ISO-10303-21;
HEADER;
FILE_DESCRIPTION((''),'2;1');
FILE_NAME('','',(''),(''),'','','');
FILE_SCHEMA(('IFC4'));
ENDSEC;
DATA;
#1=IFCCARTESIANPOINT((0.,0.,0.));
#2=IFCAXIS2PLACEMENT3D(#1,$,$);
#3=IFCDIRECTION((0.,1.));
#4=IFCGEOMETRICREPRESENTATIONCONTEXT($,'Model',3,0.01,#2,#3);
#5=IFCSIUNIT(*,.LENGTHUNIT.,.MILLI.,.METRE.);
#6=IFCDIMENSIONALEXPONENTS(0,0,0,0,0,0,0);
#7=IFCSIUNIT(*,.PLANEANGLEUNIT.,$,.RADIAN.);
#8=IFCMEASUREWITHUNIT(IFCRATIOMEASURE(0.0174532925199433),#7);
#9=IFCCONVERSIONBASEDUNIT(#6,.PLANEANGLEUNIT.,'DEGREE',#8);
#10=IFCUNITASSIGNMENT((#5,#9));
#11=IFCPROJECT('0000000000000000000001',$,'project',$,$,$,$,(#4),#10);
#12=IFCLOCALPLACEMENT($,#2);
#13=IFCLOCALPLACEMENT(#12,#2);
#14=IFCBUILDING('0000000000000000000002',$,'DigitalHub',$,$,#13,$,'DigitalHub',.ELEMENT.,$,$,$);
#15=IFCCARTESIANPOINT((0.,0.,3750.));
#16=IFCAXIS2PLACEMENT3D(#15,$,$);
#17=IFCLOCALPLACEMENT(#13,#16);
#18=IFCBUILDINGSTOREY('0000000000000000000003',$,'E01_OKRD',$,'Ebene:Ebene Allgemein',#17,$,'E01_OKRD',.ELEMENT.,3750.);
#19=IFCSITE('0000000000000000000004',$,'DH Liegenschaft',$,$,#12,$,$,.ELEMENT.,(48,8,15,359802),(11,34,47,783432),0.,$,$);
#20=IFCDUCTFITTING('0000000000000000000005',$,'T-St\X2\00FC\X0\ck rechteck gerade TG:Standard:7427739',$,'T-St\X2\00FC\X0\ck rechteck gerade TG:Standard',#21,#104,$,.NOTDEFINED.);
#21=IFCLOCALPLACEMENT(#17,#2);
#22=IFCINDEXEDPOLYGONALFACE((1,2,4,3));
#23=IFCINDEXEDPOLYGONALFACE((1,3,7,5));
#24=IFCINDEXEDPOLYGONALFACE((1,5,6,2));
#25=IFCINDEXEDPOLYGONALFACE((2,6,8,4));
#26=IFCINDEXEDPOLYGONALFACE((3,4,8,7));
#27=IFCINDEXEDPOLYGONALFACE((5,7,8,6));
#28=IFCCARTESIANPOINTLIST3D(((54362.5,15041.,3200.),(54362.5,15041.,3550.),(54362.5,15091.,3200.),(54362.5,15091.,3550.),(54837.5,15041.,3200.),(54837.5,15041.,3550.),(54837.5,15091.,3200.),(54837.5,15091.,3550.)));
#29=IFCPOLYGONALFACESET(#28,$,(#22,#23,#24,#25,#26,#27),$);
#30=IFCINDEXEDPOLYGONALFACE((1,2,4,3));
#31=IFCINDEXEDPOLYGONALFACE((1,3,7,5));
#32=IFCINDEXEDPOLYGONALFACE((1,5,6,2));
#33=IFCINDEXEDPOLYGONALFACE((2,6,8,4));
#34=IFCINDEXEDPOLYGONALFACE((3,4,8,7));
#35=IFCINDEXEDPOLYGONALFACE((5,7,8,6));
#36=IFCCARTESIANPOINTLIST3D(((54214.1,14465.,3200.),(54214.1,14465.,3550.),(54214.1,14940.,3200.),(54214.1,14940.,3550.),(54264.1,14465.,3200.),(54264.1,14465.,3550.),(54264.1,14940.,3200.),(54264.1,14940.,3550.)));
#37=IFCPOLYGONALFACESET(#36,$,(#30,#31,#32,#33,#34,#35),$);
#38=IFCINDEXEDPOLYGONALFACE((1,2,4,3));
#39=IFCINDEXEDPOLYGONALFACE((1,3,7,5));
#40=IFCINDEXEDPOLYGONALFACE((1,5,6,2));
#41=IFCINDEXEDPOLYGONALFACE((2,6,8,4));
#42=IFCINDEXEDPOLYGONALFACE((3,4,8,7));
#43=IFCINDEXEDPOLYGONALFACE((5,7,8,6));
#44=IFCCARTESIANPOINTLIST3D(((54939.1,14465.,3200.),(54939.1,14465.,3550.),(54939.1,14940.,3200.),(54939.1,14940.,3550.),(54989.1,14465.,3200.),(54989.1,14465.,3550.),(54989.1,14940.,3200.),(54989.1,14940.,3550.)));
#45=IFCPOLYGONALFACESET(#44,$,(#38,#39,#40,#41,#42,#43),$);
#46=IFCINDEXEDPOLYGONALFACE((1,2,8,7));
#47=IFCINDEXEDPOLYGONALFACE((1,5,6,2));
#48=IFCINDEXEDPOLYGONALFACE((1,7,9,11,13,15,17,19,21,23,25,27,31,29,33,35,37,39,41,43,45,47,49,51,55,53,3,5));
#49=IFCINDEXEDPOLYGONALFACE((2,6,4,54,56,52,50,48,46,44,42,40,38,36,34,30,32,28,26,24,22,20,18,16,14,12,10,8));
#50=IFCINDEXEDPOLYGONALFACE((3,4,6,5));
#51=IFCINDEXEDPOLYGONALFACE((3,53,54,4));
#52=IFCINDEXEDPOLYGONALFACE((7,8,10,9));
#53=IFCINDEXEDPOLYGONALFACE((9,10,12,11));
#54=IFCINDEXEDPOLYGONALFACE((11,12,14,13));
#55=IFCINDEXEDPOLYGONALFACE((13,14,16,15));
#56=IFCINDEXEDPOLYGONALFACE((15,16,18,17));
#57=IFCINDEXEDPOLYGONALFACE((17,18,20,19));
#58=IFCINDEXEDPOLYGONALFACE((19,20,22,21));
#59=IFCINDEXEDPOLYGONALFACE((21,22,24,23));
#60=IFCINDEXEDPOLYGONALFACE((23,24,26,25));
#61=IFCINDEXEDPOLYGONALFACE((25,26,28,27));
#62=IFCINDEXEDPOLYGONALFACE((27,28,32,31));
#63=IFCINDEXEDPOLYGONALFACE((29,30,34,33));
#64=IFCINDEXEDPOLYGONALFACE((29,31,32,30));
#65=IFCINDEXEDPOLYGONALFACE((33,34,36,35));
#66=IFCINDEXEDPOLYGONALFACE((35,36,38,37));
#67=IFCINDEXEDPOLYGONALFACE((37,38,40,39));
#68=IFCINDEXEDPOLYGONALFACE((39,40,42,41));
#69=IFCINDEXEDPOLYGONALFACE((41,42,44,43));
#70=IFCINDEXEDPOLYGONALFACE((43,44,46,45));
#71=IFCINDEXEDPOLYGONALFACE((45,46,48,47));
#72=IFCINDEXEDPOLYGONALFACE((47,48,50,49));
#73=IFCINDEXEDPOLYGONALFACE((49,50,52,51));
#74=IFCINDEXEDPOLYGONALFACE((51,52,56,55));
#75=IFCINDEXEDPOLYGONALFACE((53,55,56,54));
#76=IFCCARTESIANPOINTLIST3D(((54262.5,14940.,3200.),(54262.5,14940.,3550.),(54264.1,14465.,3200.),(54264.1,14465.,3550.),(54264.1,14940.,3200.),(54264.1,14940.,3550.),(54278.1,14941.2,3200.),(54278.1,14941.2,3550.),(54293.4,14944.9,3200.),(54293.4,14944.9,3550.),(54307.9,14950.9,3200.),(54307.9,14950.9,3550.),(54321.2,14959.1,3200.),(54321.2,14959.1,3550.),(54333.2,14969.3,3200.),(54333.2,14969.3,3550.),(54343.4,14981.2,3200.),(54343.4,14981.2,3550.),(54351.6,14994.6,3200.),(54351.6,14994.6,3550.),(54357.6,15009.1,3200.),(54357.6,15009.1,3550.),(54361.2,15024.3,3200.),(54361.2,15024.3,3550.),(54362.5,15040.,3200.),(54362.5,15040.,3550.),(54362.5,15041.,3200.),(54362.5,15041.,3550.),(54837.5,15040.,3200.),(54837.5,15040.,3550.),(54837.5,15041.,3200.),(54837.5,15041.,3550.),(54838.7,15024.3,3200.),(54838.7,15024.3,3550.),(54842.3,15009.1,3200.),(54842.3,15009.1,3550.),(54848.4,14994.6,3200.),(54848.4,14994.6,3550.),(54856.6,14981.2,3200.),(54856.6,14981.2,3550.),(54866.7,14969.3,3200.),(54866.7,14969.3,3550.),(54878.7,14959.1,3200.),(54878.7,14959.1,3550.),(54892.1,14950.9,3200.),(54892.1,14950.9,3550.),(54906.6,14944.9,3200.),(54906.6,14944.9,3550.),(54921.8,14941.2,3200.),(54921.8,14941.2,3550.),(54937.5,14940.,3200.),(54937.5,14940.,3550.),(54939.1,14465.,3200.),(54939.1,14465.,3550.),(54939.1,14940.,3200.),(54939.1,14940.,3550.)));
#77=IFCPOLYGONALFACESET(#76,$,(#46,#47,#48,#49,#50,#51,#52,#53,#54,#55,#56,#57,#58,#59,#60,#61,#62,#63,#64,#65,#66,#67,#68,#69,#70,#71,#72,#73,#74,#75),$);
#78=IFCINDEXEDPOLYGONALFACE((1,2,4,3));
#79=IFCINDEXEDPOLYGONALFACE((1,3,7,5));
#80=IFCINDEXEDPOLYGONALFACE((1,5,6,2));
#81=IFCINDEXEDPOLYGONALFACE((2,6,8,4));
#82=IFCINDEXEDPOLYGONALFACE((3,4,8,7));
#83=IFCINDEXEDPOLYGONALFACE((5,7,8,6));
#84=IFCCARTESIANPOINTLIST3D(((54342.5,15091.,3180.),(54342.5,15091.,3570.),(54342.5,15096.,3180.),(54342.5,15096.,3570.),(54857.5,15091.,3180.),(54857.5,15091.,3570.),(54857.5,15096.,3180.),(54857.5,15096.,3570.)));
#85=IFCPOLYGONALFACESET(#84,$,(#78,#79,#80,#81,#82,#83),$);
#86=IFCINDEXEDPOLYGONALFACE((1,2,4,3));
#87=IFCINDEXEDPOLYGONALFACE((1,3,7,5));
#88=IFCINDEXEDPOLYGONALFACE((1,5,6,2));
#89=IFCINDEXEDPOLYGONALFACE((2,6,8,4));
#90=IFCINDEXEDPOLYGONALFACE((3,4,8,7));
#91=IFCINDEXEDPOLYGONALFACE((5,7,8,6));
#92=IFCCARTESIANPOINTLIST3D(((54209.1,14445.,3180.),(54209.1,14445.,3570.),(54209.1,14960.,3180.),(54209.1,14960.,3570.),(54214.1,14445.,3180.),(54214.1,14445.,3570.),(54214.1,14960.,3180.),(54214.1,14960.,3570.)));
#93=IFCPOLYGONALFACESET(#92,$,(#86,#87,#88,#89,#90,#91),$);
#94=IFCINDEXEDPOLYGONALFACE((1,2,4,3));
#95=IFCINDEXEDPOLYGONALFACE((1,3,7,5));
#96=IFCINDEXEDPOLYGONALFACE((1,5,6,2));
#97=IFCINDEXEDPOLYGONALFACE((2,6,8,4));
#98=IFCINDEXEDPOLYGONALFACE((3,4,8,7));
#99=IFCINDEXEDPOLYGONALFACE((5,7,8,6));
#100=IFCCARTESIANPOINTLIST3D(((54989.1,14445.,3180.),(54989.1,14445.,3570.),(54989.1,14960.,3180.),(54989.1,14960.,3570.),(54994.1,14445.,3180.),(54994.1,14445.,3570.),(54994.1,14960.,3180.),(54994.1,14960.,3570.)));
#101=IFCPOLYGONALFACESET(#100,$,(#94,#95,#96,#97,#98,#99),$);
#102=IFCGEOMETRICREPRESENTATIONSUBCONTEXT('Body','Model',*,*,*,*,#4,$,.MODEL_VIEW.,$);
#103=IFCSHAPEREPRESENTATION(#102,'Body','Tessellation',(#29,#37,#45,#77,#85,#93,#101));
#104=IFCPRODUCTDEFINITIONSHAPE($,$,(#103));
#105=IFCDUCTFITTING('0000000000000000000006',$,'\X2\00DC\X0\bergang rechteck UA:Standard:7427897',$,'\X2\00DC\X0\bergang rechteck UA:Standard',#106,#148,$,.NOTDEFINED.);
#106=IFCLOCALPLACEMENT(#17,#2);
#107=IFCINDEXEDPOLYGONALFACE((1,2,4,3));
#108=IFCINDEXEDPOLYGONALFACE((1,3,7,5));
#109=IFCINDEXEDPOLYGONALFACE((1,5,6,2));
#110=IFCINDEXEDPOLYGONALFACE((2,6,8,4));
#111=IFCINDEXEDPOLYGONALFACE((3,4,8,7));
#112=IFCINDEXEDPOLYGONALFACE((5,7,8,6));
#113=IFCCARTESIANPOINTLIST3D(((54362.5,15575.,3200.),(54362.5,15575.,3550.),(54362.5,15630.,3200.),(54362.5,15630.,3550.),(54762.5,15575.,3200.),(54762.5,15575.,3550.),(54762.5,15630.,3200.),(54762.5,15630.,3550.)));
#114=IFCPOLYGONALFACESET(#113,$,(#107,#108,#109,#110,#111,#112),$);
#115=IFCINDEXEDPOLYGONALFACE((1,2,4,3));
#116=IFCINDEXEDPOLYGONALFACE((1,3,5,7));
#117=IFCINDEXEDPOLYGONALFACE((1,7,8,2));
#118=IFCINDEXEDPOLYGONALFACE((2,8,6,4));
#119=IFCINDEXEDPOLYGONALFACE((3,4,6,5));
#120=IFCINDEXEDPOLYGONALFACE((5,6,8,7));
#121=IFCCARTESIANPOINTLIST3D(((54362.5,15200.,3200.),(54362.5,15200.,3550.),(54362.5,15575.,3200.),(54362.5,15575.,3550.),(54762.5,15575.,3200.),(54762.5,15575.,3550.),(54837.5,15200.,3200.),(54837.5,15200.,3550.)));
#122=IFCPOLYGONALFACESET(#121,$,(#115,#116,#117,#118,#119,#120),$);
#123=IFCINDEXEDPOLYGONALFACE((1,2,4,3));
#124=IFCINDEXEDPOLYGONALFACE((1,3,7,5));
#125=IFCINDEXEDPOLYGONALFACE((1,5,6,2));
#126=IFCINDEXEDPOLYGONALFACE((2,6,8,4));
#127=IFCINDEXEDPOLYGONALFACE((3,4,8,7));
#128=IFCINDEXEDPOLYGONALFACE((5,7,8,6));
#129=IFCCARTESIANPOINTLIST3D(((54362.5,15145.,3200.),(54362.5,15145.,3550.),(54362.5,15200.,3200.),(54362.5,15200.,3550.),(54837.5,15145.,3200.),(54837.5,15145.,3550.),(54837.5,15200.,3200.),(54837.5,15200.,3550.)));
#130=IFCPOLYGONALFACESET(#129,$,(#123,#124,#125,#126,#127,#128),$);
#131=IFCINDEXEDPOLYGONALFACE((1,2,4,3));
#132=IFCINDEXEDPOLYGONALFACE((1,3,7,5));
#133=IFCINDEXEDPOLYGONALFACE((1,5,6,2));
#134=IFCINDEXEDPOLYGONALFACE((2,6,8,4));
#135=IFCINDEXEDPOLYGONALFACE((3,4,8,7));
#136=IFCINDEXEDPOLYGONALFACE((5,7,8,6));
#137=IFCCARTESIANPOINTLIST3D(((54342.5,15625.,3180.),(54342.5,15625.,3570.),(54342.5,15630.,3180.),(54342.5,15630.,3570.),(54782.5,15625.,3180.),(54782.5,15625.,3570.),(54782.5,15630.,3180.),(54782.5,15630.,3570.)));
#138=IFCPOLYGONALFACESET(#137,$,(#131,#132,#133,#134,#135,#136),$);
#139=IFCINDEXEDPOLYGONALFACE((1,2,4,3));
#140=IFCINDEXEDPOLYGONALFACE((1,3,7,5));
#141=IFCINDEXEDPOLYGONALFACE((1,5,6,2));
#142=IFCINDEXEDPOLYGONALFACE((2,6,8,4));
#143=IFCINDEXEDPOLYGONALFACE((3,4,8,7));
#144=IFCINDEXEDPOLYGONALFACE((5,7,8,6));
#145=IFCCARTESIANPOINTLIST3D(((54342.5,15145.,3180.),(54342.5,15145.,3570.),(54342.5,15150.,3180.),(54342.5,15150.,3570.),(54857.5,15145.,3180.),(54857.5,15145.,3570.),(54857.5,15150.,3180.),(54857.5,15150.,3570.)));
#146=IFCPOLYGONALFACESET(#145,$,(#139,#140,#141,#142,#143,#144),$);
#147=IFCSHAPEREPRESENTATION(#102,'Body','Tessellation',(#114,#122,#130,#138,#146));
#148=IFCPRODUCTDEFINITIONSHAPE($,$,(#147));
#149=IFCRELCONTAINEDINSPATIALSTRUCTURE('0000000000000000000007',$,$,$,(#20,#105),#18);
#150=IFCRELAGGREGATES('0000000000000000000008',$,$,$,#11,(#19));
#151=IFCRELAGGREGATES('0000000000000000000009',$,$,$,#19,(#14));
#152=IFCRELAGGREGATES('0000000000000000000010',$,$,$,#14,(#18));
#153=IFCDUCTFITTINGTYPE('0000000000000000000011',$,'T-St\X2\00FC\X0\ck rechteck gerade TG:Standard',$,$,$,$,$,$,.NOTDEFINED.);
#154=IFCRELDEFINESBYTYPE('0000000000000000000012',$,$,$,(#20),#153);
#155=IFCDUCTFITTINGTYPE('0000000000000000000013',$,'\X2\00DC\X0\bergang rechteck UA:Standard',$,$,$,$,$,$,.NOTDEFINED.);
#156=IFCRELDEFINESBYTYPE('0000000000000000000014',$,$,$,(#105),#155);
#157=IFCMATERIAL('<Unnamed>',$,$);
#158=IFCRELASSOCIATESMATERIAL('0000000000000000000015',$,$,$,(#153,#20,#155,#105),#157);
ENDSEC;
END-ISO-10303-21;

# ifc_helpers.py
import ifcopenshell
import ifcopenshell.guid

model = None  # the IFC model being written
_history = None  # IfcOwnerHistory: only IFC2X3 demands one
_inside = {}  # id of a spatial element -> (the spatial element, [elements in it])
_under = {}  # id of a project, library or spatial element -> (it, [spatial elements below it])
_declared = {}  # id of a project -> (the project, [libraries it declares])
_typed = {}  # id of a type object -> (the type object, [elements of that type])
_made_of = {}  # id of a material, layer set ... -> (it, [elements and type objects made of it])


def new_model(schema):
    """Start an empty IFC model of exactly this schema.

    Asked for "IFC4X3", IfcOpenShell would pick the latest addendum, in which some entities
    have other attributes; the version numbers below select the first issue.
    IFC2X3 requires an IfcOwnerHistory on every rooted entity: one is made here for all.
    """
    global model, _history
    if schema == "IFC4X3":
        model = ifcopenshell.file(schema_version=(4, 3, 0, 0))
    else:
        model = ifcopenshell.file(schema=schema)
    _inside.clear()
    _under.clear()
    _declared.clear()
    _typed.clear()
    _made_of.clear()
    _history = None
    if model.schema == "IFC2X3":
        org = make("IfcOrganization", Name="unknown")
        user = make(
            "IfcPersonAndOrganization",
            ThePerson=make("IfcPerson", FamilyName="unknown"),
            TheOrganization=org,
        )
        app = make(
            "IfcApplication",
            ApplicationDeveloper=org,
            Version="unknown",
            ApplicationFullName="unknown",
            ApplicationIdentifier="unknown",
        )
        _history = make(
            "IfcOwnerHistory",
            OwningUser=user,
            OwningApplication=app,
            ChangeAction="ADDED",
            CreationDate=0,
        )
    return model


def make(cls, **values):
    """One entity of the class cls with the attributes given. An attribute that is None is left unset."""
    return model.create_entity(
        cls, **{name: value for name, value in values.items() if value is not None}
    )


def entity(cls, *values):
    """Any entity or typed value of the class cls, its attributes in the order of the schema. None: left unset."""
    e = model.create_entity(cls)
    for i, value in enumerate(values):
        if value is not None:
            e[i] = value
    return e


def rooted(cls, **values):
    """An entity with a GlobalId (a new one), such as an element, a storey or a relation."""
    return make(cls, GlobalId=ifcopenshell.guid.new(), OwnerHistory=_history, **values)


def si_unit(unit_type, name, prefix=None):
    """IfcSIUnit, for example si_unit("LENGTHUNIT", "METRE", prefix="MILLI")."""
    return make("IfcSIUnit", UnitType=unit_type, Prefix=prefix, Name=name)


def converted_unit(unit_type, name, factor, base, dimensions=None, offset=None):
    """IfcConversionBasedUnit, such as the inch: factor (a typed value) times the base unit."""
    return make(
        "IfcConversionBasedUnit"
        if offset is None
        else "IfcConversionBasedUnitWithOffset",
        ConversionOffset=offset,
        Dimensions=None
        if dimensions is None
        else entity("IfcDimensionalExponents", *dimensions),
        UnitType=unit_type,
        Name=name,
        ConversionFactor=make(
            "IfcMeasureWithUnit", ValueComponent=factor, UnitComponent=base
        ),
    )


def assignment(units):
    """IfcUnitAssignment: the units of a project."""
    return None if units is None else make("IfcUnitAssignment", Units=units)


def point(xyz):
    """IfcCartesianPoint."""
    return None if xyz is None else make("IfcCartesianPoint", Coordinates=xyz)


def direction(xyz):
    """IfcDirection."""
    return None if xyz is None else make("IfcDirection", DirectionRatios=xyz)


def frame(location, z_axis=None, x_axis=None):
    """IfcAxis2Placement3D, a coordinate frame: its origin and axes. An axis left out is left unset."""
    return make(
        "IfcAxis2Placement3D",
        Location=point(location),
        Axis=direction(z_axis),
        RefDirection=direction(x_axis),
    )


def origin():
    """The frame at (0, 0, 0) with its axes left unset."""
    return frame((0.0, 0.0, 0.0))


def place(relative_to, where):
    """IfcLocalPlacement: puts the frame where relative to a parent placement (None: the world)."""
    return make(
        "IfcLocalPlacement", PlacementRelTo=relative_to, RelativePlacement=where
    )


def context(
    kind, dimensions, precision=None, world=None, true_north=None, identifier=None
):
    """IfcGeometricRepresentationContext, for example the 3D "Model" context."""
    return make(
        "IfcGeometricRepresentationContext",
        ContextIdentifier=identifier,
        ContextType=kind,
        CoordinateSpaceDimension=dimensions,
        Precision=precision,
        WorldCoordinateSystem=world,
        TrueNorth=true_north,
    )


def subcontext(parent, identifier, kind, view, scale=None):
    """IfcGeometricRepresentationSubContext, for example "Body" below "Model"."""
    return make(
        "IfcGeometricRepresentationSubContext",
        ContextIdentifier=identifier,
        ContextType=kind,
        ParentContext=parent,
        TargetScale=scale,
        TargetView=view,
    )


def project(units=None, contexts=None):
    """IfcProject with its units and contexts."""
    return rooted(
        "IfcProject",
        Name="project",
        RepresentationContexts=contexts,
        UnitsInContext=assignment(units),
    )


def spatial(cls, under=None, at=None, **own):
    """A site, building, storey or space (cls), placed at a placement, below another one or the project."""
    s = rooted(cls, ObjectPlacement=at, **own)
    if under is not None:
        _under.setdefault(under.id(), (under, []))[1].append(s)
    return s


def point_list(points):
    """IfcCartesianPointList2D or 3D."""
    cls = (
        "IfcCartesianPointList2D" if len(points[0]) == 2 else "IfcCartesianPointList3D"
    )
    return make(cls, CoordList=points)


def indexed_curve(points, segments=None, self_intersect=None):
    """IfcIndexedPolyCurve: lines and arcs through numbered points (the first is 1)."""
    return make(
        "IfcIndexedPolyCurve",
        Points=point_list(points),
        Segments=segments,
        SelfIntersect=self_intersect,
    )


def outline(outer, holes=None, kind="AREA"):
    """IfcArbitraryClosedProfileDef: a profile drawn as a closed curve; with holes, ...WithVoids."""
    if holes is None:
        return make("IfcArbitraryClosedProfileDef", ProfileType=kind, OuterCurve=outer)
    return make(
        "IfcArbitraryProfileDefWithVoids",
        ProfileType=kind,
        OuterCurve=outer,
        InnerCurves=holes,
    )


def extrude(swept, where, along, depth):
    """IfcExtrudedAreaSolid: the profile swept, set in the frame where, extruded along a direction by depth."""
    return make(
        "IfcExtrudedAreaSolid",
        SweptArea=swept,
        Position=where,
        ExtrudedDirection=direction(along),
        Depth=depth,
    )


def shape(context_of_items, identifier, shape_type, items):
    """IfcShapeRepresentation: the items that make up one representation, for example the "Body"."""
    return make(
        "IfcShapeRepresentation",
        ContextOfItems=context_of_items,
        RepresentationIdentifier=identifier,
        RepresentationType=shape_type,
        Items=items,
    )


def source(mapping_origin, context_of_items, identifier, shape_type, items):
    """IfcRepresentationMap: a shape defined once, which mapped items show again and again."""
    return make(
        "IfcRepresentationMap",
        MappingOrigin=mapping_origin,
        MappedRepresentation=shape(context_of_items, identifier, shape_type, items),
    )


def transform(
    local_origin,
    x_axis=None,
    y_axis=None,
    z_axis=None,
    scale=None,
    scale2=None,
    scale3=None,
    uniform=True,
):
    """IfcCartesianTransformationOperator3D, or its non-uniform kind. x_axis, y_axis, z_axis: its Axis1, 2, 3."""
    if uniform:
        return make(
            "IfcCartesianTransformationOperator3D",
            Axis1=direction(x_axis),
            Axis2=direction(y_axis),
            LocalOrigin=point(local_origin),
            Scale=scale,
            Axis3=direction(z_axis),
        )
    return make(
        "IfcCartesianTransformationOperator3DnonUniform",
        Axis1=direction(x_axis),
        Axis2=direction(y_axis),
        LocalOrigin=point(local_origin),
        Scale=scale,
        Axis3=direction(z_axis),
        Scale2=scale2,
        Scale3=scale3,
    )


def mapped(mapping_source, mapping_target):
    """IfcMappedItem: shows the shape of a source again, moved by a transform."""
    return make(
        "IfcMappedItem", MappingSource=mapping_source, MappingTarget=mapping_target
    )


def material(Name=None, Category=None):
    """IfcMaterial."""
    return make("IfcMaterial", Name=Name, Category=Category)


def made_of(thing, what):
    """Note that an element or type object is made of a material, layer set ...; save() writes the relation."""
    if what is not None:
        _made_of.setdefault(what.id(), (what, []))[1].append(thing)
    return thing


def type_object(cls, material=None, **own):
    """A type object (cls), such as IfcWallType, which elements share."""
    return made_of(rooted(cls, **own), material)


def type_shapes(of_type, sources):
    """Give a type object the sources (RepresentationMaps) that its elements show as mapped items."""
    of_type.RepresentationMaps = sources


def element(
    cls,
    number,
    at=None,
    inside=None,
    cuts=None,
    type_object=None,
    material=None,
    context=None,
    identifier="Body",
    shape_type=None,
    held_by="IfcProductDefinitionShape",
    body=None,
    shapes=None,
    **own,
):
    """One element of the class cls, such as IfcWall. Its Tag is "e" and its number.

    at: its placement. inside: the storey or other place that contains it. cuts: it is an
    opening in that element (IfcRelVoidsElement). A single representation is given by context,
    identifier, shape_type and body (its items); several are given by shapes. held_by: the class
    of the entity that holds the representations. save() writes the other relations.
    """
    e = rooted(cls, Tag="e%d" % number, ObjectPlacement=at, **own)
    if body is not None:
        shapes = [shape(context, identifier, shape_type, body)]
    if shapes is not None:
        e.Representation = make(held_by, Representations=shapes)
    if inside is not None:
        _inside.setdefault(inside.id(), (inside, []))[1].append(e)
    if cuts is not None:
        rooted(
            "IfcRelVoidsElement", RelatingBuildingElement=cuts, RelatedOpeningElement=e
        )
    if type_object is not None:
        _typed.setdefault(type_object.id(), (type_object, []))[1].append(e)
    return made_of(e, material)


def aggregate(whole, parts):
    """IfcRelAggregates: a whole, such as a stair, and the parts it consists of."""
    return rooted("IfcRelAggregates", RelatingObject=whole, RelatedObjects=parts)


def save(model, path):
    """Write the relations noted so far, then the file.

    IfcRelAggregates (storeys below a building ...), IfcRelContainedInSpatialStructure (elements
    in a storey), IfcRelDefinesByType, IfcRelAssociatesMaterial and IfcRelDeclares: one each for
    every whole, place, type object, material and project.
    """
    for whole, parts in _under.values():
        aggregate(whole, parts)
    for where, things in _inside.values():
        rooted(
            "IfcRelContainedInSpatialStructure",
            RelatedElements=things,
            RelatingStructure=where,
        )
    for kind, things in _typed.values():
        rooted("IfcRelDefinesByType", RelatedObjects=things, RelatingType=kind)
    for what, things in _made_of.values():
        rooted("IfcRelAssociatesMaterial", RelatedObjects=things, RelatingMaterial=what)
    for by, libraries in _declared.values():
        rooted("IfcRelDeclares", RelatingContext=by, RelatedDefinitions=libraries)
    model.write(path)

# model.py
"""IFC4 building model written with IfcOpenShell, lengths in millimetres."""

from ifc_helpers import new_model, entity, si_unit, converted_unit, direction, frame, origin, place, context, subcontext, project, spatial, indexed_curve, outline, extrude, source, transform, mapped, material, type_object, type_shapes, element, save


model = new_model("IFC4")

# Units and contexts
model_context = context("Model", 3, precision=0.01, world=origin(), true_north=direction((0.0, 1.0)))
body_context = subcontext(model_context, "Body", "Model", "MODEL_VIEW")
ifc_project = project(units=[si_unit("LENGTHUNIT", "METRE", prefix="MILLI"), converted_unit("PLANEANGLEUNIT", "DEGREE", entity("IfcRatioMeasure", 0.0174532925199433), si_unit("PLANEANGLEUNIT", "RADIAN"), dimensions=[0, 0, 0, 0, 0, 0, 0])], contexts=[model_context])

# Site, building, storey
site_placement = place(None, origin())
site = spatial("IfcSite", under=ifc_project, at=site_placement, Name="DH Liegenschaft", CompositionType="ELEMENT", RefLatitude=(48, 8, 15, 359802), RefLongitude=(11, 34, 47, 783432), RefElevation=0.0)
building_placement = place(site_placement, origin())
building = spatial("IfcBuilding", under=site, at=building_placement, Name="DigitalHub", LongName="DigitalHub", CompositionType="ELEMENT")
storey_placement = place(building_placement, frame((0.0, 0.0, 3750.0)))
storey = spatial("IfcBuildingStorey", under=building, at=storey_placement, Name="E01_OKRD", ObjectType="Ebene:Ebene Allgemein", LongName="E01_OKRD", CompositionType="ELEMENT", Elevation=3750.0)

# Shared definitions
ifc_material_1 = material(Name="<Unnamed>")

# Duct fittings
duct_fitting_type_1 = type_object("IfcDuctFittingType", Name="T-Stück rechteck gerade TG:Standard", PredefinedType="NOTDEFINED", material=ifc_material_1)
shared_shape_1 = source(origin(), body_context, "Body", "SweptSolid", [
    extrude(outline(indexed_curve([(-25.0, -237.5), (25.0, -237.5), (25.0, 237.5), (-25.0, 237.5), (-25.0, -237.5)], self_intersect=False)), frame((0.0, -363.5, -175.0), z_axis=(0.0, 0.0, 1.0), x_axis=(0.0, -1.0, 0.0)), (0.0, 0.0, 1.0), 350.0),
    extrude(outline(indexed_curve([(-25.0, -237.5), (25.0, -237.5), (25.0, 237.5), (-25.0, 237.5), (-25.0, -237.5)], self_intersect=False)), frame((360.9, 0.0, -175.0), z_axis=(0.0, 0.0, 1.0), x_axis=(-1.0, 0.0, 0.0)), (0.0, 0.0, 1.0), 350.0),
    extrude(outline(indexed_curve([(-25.0, -237.5), (25.0, -237.5), (25.0, 237.5), (-25.0, 237.5), (-25.0, -237.5)], self_intersect=False)), frame((-364.1, 0.0, -175.0)), (0.0, 0.0, 1.0), 350.0),
    extrude(outline(indexed_curve([(-338.1, -54.8), (-322.5, -56.0), (-307.2, -59.7), (-292.7, -65.7), (-279.4, -73.9), (-267.4, -84.1), (-257.2, -96.0), (-249.0, -109.4), (-243.0, -123.9), (-239.4, -139.2), (-238.1, -154.8), (-238.1, -155.8), (236.9, -155.8), (236.9, -154.8), (238.1, -139.2), (241.8, -123.9), (247.8, -109.4), (256.0, -96.0), (266.1, -84.1), (278.1, -73.9), (291.5, -65.7), (306.0, -59.7), (321.2, -56.0), (336.9, -54.8), (338.5, -54.8), (338.5, 420.2), (-336.5, 420.2), (-336.5, -54.8), (-338.1, -54.8)], self_intersect=False)), frame((-0.6, -182.7, -175.0), z_axis=(0.0, 0.0, -1.0), x_axis=(-1.0, 0.0, 0.0)), (0.0, 0.0, -1.0), 350.0),
    extrude(outline(indexed_curve([(-2.5, -257.5), (2.5, -257.5), (2.5, 257.5), (-2.5, 257.5), (-2.5, -257.5)], self_intersect=False)), frame((0.0, -391.0, -195.0), z_axis=(0.0, 0.0, 1.0), x_axis=(0.0, 1.0, 0.0)), (0.0, 0.0, 1.0), 390.0),
    extrude(outline(indexed_curve([(-2.5, -257.5), (2.5, -257.5), (2.5, 257.5), (-2.5, 257.5), (-2.5, -257.5)], self_intersect=False)), frame((388.4, 0.0, -195.0), z_axis=(0.0, 0.0, 1.0), x_axis=(-1.0, 0.0, 0.0)), (0.0, 0.0, 1.0), 390.0),
    extrude(outline(indexed_curve([(-2.5, -257.5), (2.5, -257.5), (2.5, 257.5), (-2.5, 257.5), (-2.5, -257.5)], self_intersect=False)), frame((-391.6, 0.0, -195.0), z_axis=(0.0, 0.0, 1.0), x_axis=(-1.0, 0.0, 0.0)), (0.0, 0.0, 1.0), 390.0),
])
type_shapes(duct_fitting_type_1, [shared_shape_1])
duct_fitting_1_placement = place(storey_placement, frame((54600.0, 14702.5, 3375.0), z_axis=(0.0, 0.0, 1.0), x_axis=(-1.0, 0.0, 0.0)))
element("IfcDuctFitting", 1, at=duct_fitting_1_placement, inside=storey, type_object=duct_fitting_type_1, material=ifc_material_1, Name="T-Stück rechteck gerade TG:Standard:7427739", ObjectType="T-Stück rechteck gerade TG:Standard", PredefinedType="NOTDEFINED", context=body_context, shape_type="MappedRepresentation", body=[
    mapped(shared_shape_1, transform((0.0, 0.0, 0.0), scale=1.0)),
])
duct_fitting_type_2 = type_object("IfcDuctFittingType", Name="Übergang rechteck UA:Standard", PredefinedType="NOTDEFINED", material=ifc_material_1)
shared_shape_2 = source(origin(), body_context, "Body", "SweptSolid", [
    extrude(outline(indexed_curve([(-27.5, -200.0), (27.5, -200.0), (27.5, 200.0), (-27.5, 200.0), (-27.5, -200.0)], self_intersect=False)), frame((457.5, 37.5, -175.0)), (0.0, 0.0, 1.0), 350.0),
    extrude(outline(indexed_curve([(-234.1, -214.5), (148.3, -214.5), (226.8, 177.7), (-141.0, 251.3), (-234.1, -214.5)], self_intersect=False)), frame((242.5, 18.8, -175.0), z_axis=(0.0, 0.0, 1.0), x_axis=(0.980581, 0.196116, 0.0)), (0.0, 0.0, 1.0), 350.0),
    extrude(outline(indexed_curve([(-27.5, -237.5), (27.5, -237.5), (27.5, 237.5), (-27.5, 237.5), (-27.5, -237.5)], self_intersect=False)), frame((27.5, 0.0, -175.0)), (0.0, 0.0, 1.0), 350.0),
    extrude(outline(indexed_curve([(-2.5, -220.0), (2.5, -220.0), (2.5, 220.0), (-2.5, 220.0), (-2.5, -220.0)], self_intersect=False)), frame((482.5, 37.5, -195.0)), (0.0, 0.0, 1.0), 390.0),
    extrude(outline(indexed_curve([(-2.5, -257.5), (2.5, -257.5), (2.5, 257.5), (-2.5, 257.5), (-2.5, -257.5)], self_intersect=False)), frame((2.5, 0.0, -195.0)), (0.0, 0.0, 1.0), 390.0),
])
type_shapes(duct_fitting_type_2, [shared_shape_2])
duct_fitting_2_placement = place(storey_placement, frame((54600.0, 15145.0, 3375.0), z_axis=(0.0, 0.0, 1.0), x_axis=(0.0, 1.0, 0.0)))
element("IfcDuctFitting", 2, at=duct_fitting_2_placement, inside=storey, type_object=duct_fitting_type_2, material=ifc_material_1, Name="Übergang rechteck UA:Standard:7427897", ObjectType="Übergang rechteck UA:Standard", PredefinedType="NOTDEFINED", context=body_context, shape_type="MappedRepresentation", body=[
    mapped(shared_shape_2, transform((0.0, 0.0, 0.0), scale=1.0)),
])

save(model, "model.ifc")
